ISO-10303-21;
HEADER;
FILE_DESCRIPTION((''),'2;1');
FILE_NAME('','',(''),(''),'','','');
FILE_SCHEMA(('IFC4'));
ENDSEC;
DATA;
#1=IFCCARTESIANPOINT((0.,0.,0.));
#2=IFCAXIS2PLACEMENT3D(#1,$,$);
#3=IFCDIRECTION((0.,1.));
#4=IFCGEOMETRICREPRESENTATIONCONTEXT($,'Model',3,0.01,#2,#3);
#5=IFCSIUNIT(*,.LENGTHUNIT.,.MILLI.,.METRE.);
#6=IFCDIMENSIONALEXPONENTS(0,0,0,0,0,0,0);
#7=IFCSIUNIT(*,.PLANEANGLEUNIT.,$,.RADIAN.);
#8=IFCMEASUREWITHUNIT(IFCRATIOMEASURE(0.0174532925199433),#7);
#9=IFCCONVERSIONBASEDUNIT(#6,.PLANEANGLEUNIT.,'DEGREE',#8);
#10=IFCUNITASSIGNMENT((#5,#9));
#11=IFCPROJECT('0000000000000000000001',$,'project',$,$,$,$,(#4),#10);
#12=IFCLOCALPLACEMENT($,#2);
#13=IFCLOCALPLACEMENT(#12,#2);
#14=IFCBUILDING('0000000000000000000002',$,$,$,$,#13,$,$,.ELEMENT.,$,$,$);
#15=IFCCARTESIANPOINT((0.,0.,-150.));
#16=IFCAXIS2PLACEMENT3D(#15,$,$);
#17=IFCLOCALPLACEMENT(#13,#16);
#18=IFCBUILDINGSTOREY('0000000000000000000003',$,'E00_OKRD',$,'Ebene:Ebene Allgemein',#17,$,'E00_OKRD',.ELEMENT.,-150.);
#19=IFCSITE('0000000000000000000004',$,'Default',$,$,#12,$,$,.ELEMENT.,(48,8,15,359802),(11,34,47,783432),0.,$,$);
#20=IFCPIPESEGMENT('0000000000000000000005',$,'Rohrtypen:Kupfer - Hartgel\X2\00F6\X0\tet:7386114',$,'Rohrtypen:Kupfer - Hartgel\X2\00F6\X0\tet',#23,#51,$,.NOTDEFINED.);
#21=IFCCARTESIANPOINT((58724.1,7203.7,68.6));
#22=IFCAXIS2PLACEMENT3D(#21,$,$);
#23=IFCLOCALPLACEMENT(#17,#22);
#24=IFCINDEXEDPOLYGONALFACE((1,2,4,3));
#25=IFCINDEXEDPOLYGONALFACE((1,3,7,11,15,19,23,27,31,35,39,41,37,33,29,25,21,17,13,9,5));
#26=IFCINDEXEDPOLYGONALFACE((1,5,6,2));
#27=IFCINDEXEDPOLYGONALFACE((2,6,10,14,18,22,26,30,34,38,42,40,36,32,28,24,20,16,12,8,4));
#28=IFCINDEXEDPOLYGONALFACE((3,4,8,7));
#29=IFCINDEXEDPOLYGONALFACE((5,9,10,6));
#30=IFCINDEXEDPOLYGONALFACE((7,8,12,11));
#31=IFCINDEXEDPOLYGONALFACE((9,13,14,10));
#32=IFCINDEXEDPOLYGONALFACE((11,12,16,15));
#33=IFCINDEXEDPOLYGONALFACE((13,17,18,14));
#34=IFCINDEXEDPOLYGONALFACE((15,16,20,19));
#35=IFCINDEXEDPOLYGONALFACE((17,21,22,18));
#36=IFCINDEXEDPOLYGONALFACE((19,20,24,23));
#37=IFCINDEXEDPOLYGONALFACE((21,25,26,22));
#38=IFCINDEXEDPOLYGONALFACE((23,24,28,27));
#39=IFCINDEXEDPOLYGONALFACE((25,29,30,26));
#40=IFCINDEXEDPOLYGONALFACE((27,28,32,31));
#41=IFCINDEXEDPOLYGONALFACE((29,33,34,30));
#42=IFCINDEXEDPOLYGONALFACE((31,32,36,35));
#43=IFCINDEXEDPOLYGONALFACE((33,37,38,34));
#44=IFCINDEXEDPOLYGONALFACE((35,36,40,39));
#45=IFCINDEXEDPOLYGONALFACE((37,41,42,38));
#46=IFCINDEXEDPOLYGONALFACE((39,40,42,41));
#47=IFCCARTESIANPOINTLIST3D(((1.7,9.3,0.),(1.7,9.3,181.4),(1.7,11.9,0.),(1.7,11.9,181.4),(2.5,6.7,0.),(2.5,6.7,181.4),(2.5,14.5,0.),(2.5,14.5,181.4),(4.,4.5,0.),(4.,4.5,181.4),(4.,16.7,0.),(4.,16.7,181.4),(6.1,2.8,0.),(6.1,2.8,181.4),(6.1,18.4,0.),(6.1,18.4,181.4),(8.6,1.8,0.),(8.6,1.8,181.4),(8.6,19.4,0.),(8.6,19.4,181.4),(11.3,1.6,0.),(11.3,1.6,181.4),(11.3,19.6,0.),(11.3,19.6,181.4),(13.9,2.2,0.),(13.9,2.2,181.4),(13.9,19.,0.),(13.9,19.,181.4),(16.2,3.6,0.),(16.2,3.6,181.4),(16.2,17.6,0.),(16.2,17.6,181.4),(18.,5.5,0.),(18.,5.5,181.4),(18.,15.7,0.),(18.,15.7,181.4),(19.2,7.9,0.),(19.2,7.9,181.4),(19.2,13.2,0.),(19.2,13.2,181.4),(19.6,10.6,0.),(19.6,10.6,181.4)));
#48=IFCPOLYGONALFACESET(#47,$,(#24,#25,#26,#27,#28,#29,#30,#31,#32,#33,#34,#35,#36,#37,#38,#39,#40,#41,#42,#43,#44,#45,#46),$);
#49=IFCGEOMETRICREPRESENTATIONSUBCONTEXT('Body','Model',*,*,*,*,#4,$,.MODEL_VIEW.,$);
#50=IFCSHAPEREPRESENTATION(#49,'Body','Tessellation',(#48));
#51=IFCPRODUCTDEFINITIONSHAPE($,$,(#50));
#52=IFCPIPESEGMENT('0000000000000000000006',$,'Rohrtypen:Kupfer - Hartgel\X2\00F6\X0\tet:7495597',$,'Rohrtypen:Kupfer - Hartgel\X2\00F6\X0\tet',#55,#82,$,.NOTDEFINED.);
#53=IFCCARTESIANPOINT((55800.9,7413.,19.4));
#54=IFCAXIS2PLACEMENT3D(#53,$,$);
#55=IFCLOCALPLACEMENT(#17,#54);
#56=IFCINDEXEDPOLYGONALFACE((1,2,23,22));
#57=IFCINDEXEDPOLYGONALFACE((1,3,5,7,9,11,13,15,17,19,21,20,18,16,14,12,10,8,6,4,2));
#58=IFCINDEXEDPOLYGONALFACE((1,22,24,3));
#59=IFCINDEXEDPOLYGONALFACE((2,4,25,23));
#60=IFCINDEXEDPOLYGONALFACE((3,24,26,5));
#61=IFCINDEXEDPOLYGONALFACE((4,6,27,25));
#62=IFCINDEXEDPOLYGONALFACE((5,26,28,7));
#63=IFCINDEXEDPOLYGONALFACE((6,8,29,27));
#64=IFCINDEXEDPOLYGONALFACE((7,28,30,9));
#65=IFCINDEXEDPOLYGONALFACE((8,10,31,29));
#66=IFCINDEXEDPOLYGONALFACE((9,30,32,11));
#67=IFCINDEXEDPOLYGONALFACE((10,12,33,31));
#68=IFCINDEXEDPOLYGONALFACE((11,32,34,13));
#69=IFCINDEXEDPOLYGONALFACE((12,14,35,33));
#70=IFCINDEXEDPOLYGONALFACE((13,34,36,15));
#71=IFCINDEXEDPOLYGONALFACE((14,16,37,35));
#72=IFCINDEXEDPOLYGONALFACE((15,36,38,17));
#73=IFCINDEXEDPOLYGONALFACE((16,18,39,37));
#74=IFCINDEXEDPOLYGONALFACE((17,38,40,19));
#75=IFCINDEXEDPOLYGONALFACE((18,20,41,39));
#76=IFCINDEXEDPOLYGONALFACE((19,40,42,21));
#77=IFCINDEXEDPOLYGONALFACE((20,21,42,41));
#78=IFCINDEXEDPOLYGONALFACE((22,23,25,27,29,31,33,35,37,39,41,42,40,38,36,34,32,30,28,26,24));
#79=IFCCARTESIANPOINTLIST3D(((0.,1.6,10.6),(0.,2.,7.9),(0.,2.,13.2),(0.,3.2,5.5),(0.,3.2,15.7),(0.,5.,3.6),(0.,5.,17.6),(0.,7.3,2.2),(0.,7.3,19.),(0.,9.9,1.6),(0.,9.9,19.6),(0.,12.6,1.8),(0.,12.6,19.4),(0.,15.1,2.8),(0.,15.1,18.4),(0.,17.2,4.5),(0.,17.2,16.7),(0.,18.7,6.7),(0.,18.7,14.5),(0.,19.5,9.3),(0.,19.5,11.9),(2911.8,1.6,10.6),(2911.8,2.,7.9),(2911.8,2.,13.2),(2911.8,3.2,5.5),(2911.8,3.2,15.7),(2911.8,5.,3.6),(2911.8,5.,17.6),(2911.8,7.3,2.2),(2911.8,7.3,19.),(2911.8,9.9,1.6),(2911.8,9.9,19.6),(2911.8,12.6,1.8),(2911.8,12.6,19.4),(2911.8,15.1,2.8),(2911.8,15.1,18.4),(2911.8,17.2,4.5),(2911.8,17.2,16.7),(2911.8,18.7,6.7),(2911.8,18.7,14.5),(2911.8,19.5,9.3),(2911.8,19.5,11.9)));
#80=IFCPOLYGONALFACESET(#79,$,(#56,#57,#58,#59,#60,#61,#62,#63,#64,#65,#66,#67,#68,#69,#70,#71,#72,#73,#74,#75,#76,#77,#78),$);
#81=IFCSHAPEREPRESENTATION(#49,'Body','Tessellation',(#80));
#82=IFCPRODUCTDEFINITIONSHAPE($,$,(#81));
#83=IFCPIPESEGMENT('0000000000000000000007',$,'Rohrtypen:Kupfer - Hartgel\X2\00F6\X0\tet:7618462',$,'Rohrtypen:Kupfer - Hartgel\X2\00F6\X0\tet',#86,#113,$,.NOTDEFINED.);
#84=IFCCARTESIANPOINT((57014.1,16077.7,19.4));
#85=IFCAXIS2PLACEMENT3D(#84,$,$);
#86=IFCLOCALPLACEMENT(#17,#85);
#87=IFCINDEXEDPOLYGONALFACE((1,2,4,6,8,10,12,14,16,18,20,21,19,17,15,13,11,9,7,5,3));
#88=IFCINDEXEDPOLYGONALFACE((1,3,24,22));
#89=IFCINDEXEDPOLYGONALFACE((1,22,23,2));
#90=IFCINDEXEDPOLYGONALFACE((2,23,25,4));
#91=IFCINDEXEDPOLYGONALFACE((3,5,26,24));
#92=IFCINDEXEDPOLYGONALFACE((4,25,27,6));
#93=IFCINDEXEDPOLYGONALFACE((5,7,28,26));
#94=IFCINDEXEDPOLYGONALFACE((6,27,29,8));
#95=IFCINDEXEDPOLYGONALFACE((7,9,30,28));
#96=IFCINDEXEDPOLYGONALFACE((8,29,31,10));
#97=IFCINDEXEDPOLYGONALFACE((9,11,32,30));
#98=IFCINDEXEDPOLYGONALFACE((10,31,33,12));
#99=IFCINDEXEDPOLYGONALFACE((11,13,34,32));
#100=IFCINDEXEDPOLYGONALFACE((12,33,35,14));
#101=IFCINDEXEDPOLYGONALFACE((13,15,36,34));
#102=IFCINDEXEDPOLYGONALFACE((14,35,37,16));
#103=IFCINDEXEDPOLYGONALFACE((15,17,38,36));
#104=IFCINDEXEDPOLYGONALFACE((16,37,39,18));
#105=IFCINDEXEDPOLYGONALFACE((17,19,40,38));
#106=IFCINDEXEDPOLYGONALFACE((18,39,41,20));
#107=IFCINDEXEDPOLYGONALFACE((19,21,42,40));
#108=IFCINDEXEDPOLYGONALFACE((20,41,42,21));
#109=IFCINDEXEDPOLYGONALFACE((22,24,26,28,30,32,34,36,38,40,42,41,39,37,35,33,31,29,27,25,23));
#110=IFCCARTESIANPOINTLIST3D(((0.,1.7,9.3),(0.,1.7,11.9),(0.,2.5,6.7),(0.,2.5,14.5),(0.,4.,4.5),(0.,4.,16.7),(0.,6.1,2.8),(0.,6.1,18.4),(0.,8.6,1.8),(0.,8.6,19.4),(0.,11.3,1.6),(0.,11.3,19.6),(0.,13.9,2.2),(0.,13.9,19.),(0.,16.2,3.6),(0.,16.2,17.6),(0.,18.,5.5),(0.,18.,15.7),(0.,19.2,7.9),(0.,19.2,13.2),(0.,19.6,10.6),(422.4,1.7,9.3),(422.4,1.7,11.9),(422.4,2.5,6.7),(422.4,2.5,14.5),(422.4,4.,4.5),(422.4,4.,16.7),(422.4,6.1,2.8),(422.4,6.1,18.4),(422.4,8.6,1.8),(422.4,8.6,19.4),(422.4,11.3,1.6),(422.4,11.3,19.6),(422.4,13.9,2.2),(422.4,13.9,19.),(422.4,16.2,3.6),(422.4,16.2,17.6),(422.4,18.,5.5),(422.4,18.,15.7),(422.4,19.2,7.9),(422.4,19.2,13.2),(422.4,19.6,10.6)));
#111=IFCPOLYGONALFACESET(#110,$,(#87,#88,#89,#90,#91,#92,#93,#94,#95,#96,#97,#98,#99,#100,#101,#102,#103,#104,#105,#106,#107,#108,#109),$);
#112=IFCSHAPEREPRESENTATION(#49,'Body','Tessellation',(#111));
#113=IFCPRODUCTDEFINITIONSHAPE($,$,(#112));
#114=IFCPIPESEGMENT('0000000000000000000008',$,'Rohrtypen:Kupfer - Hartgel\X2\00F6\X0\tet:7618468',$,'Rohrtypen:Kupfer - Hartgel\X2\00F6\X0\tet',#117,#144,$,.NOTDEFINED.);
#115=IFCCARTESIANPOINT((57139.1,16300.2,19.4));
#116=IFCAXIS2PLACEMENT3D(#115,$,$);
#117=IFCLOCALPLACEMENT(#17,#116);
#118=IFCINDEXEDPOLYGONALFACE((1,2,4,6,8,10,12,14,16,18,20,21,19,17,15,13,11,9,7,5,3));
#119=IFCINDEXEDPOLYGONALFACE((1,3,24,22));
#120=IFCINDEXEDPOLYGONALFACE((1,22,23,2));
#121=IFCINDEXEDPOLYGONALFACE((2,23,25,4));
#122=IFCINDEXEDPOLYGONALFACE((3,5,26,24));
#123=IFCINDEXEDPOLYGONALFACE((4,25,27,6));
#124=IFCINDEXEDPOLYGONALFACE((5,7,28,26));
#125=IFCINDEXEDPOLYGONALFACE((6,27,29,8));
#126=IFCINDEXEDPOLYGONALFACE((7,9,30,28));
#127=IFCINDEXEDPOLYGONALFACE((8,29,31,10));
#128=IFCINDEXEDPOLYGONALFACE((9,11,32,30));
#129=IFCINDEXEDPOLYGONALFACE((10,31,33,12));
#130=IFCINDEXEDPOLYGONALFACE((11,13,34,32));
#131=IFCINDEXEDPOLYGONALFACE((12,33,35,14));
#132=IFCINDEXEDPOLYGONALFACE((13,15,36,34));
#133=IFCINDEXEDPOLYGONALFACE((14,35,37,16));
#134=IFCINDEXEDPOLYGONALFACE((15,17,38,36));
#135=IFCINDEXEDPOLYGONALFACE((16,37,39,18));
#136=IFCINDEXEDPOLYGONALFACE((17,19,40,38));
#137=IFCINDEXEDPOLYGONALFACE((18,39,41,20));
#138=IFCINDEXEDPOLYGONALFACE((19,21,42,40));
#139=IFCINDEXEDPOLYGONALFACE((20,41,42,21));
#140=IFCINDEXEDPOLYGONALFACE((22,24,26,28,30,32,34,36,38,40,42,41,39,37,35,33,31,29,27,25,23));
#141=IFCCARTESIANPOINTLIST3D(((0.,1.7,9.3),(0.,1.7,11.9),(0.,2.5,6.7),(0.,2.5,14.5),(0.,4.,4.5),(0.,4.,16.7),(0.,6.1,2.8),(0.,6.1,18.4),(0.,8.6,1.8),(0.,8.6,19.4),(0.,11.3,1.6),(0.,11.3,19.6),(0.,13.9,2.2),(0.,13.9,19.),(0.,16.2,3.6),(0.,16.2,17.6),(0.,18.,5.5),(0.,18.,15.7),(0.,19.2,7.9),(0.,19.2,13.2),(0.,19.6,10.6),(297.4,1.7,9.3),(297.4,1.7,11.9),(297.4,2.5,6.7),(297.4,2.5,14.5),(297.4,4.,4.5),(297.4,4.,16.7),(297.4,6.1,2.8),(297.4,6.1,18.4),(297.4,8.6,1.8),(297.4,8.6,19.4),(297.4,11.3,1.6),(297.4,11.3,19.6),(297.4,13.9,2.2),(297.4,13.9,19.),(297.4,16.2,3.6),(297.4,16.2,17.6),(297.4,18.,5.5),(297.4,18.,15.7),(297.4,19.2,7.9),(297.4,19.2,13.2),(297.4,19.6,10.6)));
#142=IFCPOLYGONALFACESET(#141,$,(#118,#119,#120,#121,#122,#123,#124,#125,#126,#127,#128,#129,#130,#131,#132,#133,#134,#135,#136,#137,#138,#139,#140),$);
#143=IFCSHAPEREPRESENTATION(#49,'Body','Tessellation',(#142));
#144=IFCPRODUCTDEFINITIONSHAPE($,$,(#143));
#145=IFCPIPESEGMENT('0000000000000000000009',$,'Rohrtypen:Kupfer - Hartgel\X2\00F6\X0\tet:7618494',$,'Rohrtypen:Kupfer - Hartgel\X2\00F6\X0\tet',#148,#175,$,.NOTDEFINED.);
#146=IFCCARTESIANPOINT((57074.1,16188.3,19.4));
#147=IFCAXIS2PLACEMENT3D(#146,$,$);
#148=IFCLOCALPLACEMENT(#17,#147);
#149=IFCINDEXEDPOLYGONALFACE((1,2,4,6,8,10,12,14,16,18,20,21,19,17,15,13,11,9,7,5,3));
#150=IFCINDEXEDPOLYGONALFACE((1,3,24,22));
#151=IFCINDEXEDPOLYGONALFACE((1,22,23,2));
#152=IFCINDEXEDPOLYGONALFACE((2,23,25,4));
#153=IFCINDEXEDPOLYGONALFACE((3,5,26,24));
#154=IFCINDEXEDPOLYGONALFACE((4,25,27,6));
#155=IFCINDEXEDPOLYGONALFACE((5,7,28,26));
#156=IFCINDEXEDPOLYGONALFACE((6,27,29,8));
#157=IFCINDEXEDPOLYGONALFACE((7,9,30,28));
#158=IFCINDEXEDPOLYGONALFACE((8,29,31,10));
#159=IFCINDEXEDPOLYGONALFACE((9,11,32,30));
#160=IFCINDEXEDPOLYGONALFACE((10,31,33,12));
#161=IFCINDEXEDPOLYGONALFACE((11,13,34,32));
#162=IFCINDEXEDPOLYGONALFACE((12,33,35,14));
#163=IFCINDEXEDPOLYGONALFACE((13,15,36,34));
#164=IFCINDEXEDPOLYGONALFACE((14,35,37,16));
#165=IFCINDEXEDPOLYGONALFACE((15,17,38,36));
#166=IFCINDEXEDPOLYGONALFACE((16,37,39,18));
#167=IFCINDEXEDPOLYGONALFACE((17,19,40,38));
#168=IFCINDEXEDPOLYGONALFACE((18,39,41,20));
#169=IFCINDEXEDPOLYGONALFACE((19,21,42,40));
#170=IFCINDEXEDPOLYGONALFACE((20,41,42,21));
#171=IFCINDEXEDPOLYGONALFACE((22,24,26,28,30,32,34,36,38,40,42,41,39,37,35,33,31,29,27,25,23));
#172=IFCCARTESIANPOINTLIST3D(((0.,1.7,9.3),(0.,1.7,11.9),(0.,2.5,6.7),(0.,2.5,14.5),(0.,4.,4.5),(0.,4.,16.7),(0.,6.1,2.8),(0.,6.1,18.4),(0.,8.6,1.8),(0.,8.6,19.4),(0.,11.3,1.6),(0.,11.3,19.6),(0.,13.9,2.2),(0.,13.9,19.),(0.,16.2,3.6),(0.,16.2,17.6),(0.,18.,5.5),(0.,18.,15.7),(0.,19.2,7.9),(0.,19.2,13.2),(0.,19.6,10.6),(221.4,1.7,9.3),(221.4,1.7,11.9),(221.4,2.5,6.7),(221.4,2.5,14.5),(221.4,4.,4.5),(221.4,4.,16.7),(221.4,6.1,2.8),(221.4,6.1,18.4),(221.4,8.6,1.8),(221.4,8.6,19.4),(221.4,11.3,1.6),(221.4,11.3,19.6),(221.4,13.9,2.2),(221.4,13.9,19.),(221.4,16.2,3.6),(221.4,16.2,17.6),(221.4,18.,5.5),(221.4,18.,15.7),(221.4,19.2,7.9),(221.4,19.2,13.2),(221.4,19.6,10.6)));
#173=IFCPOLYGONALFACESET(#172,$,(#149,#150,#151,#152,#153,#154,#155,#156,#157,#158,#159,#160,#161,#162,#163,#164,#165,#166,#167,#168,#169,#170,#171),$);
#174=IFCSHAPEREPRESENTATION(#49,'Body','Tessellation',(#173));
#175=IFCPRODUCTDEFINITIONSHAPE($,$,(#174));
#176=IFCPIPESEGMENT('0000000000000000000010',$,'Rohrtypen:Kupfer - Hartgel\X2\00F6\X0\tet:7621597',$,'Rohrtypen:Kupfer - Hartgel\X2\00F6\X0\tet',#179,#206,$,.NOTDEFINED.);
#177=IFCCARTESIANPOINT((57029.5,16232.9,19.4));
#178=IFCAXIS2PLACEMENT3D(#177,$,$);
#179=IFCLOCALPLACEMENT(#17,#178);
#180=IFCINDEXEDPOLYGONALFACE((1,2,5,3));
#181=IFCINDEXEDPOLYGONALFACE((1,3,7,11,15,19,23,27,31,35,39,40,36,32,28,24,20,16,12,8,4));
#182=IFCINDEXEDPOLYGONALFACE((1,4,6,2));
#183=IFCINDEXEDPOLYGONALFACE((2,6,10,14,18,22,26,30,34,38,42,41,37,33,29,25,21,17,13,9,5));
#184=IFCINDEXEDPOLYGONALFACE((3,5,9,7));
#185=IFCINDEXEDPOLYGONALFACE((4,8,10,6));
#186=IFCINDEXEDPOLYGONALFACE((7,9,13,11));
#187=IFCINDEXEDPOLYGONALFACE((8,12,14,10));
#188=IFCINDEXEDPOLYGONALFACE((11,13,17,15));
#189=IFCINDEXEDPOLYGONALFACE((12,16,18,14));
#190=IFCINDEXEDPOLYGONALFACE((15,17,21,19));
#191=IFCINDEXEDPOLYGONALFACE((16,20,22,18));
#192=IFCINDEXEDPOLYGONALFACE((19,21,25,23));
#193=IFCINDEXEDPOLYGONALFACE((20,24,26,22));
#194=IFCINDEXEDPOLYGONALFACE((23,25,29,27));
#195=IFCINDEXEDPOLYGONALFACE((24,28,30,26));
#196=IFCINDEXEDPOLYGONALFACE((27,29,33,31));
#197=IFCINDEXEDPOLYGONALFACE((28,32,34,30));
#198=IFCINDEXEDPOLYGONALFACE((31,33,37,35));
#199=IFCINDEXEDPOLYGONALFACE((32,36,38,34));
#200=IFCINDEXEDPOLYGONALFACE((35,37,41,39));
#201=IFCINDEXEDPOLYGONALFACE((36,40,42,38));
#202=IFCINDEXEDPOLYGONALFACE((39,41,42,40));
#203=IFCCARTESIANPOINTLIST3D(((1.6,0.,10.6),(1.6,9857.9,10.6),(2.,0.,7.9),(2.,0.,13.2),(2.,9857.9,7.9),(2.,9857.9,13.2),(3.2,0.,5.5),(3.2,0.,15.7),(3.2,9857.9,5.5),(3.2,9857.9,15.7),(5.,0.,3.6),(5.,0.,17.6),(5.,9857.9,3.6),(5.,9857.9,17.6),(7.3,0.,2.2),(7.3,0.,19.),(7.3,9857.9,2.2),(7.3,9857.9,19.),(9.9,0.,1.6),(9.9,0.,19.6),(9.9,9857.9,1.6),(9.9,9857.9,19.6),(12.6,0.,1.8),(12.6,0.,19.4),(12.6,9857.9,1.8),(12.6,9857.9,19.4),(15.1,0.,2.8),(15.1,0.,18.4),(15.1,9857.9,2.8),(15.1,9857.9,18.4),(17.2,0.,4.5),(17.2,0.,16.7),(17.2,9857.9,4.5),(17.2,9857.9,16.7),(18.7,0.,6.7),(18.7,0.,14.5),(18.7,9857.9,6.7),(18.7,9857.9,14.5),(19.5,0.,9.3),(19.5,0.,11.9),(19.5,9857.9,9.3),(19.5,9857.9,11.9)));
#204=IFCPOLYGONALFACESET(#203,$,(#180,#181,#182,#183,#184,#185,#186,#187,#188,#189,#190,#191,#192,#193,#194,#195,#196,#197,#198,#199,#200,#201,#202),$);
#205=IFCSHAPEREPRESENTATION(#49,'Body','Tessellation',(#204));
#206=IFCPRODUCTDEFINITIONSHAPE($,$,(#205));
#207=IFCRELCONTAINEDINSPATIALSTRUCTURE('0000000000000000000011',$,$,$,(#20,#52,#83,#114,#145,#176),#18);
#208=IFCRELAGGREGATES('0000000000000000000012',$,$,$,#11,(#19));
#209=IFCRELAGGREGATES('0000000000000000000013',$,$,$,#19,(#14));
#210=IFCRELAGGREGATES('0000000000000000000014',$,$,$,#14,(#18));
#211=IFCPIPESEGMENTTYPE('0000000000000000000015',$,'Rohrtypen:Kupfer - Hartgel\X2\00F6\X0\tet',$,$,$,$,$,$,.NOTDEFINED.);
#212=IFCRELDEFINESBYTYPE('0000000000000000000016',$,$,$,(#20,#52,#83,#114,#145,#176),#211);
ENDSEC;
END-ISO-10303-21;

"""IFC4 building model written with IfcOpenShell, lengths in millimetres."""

from ifc_helpers import new_model, entity, si_unit, converted_unit, direction, frame, frame_2d, origin, origin_2d_with_axis, place, context, subcontext, project, spatial, circle, extrude, type_object, element, save


model = new_model("IFC4")

# Units and contexts
model_context = context("Model", 3, precision=0.01, world=origin(), true_north=direction((0.0, 1.0)))
body_context = subcontext(model_context, "Body", "Model", "MODEL_VIEW")
ifc_project = project(units=[si_unit("LENGTHUNIT", "METRE", prefix="MILLI"), converted_unit("PLANEANGLEUNIT", "DEGREE", entity("IfcRatioMeasure", 0.0174532925199433), si_unit("PLANEANGLEUNIT", "RADIAN"), dimensions=[0, 0, 0, 0, 0, 0, 0])], contexts=[model_context])

# Site, building, storey
site_placement = place(None, origin())
site = spatial("IfcSite", under=ifc_project, at=site_placement, Name="Default", CompositionType="ELEMENT", RefLatitude=(48, 8, 15, 359802), RefLongitude=(11, 34, 47, 783432), RefElevation=0.0)
building_placement = place(site_placement, origin())
building = spatial("IfcBuilding", under=site, at=building_placement, CompositionType="ELEMENT")
storey_placement = place(building_placement, frame((0.0, 0.0, -150.0)))
storey = spatial("IfcBuildingStorey", under=building, at=storey_placement, Name="E00_OKRD", ObjectType="Ebene:Ebene Allgemein", LongName="E00_OKRD", CompositionType="ELEMENT", Elevation=-150.0)

# Pipe segments
pipe_segment_type = type_object("IfcPipeSegmentType", Name="Rohrtypen:Kupfer - Hartgelötet", PredefinedType="NOTDEFINED")
pipe_segment_1_placement = place(storey_placement, frame((58724.1, 7203.7, 68.6)))
element("IfcPipeSegment", 1, at=pipe_segment_1_placement, inside=storey, type_object=pipe_segment_type, Name="Rohrtypen:Kupfer - Hartgelötet:7386114", ObjectType="Rohrtypen:Kupfer - Hartgelötet", PredefinedType="NOTDEFINED", context=body_context, shape_type="SweptSolid", body=[
    extrude(circle(Radius=9.0, at=origin_2d_with_axis()), frame((10.6, 10.6, 0.0)), (0.0, 0.0, 1.0), 181.4),
])
pipe_segment_2_placement = place(storey_placement, frame((55800.9, 7413.0, 19.4)))
element("IfcPipeSegment", 2, at=pipe_segment_2_placement, inside=storey, type_object=pipe_segment_type, Name="Rohrtypen:Kupfer - Hartgelötet:7495597", ObjectType="Rohrtypen:Kupfer - Hartgelötet", PredefinedType="NOTDEFINED", context=body_context, shape_type="SweptSolid", body=[
    extrude(circle(Radius=9.0, at=frame_2d((0.0, 0.0), x_axis=(1.0, 0.0))), frame((0.0, 10.6, 10.6), z_axis=(1.0, 0.0, 0.0), x_axis=(0.0, -1.0, 0.0)), (0.0, 0.0, 1.0), 2911.8),
])
pipe_segment_3_placement = place(storey_placement, frame((57014.1, 16077.7, 19.4)))
element("IfcPipeSegment", 3, at=pipe_segment_3_placement, inside=storey, type_object=pipe_segment_type, Name="Rohrtypen:Kupfer - Hartgelötet:7618462", ObjectType="Rohrtypen:Kupfer - Hartgelötet", PredefinedType="NOTDEFINED", context=body_context, shape_type="SweptSolid", body=[
    extrude(circle(Radius=9.0, at=frame_2d((0.0, 0.0), x_axis=(1.0, 0.0))), frame((0.0, 10.6, 10.6), z_axis=(1.0, 0.0, 0.0), x_axis=(0.0, 1.0, 0.0)), (0.0, 0.0, 1.0), 422.4),
])
pipe_segment_4_placement = place(storey_placement, frame((57139.1, 16300.2, 19.4)))
element("IfcPipeSegment", 4, at=pipe_segment_4_placement, inside=storey, type_object=pipe_segment_type, Name="Rohrtypen:Kupfer - Hartgelötet:7618468", ObjectType="Rohrtypen:Kupfer - Hartgelötet", PredefinedType="NOTDEFINED", context=body_context, shape_type="SweptSolid", body=[
    extrude(circle(Radius=9.0, at=frame_2d((0.0, 0.0), x_axis=(1.0, 0.0))), frame((0.0, 10.6, 10.6), z_axis=(1.0, 0.0, 0.0), x_axis=(0.0, 1.0, 0.0)), (0.0, 0.0, 1.0), 297.4),
])
pipe_segment_5_placement = place(storey_placement, frame((57074.1, 16188.3, 19.4)))
element("IfcPipeSegment", 5, at=pipe_segment_5_placement, inside=storey, type_object=pipe_segment_type, Name="Rohrtypen:Kupfer - Hartgelötet:7618494", ObjectType="Rohrtypen:Kupfer - Hartgelötet", PredefinedType="NOTDEFINED", context=body_context, shape_type="SweptSolid", body=[
    extrude(circle(Radius=9.0, at=frame_2d((0.0, 0.0), x_axis=(1.0, 0.0))), frame((0.0, 10.6, 10.6), z_axis=(1.0, 0.0, 0.0), x_axis=(0.0, 1.0, 0.0)), (0.0, 0.0, 1.0), 221.4),
])
pipe_segment_6_placement = place(storey_placement, frame((57029.5, 16232.9, 19.4)))
element("IfcPipeSegment", 6, at=pipe_segment_6_placement, inside=storey, type_object=pipe_segment_type, Name="Rohrtypen:Kupfer - Hartgelötet:7621597", ObjectType="Rohrtypen:Kupfer - Hartgelötet", PredefinedType="NOTDEFINED", context=body_context, shape_type="SweptSolid", body=[
    extrude(circle(Radius=9.0, at=frame_2d((0.0, 0.0), x_axis=(1.0, 0.0))), frame((10.6, 0.0, 10.6), z_axis=(0.0, 1.0, 0.0), x_axis=(-1.0, 0.0, 0.0)), (0.0, 0.0, 1.0), 9857.9),
])

save(model, "model.ifc")
